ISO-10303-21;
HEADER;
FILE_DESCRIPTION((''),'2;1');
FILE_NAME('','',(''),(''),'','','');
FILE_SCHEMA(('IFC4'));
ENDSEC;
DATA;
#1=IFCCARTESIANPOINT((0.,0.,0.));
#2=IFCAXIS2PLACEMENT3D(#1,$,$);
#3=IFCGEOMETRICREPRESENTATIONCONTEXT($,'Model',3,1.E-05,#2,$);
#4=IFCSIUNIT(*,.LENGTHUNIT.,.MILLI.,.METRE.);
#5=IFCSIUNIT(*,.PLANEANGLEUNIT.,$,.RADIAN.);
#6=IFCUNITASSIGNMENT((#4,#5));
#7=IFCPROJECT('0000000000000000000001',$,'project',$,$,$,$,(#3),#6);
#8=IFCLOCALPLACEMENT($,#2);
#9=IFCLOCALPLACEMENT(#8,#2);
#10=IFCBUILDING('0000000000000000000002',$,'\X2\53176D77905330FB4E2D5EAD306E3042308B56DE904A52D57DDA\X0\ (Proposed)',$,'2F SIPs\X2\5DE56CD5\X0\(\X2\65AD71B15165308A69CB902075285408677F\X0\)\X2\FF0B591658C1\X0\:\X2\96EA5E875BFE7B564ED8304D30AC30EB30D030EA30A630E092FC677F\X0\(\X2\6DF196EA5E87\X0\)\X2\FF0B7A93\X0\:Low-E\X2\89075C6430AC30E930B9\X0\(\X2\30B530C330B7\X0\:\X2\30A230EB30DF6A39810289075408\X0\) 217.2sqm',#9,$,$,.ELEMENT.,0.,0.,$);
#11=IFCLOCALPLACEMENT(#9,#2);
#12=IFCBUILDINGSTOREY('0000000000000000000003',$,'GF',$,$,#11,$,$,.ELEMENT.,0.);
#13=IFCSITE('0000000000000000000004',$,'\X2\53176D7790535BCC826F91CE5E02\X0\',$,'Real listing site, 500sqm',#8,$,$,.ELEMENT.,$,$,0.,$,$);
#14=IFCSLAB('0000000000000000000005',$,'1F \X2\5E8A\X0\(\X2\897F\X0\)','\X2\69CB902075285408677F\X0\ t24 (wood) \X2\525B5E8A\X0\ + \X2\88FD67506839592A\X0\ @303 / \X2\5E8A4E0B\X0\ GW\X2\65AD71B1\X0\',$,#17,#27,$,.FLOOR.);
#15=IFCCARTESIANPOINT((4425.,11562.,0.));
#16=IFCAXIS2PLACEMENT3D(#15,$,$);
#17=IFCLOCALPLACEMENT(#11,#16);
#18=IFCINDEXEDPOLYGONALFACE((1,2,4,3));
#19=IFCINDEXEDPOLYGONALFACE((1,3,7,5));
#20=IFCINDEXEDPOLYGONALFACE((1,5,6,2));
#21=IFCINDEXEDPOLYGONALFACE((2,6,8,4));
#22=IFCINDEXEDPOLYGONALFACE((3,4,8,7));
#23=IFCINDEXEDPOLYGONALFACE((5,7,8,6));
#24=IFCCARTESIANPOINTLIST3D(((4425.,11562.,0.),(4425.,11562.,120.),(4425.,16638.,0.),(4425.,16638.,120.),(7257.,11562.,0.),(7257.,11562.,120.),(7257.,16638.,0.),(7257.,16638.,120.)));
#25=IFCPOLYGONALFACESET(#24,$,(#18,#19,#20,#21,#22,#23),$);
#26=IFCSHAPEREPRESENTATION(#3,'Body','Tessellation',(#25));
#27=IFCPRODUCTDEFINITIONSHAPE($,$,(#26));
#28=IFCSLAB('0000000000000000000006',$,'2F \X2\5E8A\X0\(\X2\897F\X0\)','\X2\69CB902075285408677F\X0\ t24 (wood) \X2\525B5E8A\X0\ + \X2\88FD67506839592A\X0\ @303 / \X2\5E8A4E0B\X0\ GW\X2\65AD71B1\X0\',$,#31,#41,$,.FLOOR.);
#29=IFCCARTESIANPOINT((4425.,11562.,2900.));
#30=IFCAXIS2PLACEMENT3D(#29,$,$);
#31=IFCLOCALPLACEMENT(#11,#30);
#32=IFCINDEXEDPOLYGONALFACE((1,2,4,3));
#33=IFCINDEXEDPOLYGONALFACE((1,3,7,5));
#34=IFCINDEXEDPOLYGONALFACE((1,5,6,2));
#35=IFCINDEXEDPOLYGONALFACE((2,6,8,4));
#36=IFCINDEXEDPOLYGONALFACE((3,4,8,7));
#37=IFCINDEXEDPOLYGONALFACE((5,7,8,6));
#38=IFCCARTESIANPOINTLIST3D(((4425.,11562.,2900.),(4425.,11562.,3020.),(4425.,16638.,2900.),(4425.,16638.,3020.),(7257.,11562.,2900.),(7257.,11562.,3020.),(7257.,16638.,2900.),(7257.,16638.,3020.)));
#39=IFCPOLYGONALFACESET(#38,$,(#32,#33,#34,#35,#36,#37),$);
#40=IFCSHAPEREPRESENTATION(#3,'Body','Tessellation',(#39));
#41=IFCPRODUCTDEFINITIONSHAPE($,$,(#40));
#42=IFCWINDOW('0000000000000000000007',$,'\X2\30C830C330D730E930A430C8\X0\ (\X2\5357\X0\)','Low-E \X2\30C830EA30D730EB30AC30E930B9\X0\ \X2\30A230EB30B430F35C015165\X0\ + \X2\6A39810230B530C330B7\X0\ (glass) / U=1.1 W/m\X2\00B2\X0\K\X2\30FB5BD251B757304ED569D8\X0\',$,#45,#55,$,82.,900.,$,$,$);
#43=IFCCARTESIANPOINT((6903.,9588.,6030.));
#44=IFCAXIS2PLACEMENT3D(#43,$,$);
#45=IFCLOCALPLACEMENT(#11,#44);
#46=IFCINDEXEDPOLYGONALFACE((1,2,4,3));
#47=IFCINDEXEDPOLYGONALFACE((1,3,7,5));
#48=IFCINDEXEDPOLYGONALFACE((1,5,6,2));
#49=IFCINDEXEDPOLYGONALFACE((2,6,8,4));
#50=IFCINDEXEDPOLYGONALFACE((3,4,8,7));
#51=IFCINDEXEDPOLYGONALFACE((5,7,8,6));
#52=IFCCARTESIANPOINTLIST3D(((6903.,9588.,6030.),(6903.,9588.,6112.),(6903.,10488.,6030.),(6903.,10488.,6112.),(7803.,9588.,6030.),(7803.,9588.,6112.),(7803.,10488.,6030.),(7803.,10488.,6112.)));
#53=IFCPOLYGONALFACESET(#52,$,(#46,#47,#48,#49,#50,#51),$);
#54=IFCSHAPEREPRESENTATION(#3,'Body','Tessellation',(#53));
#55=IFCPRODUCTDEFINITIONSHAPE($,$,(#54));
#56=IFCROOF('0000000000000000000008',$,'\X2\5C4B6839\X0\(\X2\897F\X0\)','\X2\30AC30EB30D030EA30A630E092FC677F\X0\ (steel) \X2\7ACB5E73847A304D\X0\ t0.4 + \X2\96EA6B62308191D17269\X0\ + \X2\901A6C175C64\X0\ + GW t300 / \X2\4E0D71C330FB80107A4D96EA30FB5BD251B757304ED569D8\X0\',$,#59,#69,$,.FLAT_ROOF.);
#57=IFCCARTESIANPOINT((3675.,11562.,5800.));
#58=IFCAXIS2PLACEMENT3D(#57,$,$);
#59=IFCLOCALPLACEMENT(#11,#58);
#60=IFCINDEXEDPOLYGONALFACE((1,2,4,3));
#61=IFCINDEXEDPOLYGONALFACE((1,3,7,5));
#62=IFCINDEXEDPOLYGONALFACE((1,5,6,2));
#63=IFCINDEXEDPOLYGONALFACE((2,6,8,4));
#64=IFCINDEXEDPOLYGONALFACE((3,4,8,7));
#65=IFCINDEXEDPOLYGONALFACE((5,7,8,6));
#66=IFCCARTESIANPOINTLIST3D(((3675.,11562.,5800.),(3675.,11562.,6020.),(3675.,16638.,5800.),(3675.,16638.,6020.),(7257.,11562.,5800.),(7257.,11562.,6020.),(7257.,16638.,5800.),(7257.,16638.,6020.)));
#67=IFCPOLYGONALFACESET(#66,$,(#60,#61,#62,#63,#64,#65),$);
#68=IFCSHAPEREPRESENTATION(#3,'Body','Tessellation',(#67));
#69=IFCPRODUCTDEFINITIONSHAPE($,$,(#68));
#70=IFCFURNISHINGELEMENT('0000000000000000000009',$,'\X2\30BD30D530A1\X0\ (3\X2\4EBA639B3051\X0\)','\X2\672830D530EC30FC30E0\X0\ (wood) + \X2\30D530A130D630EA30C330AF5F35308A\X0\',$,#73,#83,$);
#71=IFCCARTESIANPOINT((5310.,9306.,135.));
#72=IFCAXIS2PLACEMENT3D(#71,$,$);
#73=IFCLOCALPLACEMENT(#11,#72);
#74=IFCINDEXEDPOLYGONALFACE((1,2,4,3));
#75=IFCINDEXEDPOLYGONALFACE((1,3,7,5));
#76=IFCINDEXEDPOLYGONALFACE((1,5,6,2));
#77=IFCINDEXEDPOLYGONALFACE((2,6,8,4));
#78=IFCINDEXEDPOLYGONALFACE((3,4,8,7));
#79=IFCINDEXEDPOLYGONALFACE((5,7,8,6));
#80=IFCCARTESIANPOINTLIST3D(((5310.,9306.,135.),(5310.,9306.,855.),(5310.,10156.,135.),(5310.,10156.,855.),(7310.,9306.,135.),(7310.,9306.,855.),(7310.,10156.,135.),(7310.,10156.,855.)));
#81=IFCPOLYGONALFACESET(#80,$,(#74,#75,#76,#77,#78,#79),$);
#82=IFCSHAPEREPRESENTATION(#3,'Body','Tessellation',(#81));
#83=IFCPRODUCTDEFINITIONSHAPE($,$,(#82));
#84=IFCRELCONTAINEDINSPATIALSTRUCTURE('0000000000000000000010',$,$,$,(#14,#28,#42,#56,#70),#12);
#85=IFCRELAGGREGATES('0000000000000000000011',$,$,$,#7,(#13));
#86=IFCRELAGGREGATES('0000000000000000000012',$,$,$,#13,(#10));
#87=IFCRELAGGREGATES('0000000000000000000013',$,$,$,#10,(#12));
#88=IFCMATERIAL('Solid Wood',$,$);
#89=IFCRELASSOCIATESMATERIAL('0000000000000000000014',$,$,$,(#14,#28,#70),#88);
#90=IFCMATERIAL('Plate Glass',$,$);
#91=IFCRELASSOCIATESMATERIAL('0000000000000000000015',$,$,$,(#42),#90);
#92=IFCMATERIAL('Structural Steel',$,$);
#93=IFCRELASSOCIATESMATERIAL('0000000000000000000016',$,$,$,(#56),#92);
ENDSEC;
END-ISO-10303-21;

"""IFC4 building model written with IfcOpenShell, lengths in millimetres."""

from ifc_helpers import new_model, si_unit, frame, frame_2d, origin, place, context, project, spatial, rectangle, extrude, material, element, save


model = new_model("IFC4")

# Units and contexts
model_context = context("Model", 3, precision=1e-05, world=origin())
ifc_project = project(units=[si_unit("LENGTHUNIT", "METRE", prefix="MILLI"), si_unit("PLANEANGLEUNIT", "RADIAN")], contexts=[model_context])

# Site, building, storey
site_placement = place(None, origin())
site = spatial("IfcSite", under=ifc_project, at=site_placement, Name="北海道富良野市", ObjectType="Real listing site, 500sqm", CompositionType="ELEMENT", RefElevation=0.0)
building_placement = place(site_placement, origin())
building = spatial("IfcBuilding", under=site, at=building_placement, Name="北海道・中庭のある回遊動線 (Proposed)", ObjectType="2F SIPs工法(断熱入り構造用合板)＋外壁:雪庇対策付きガルバリウム鋼板(深雪庇)＋窓:Low-E複層ガラス(サッシ:アルミ樹脂複合) 217.2sqm", CompositionType="ELEMENT", ElevationOfRefHeight=0.0, ElevationOfTerrain=0.0)
storey_placement = place(building_placement, origin())
storey = spatial("IfcBuildingStorey", under=building, at=storey_placement, Name="GF", CompositionType="ELEMENT", Elevation=0.0)

# Shared definitions
ifc_material_1 = material(Name="Solid Wood")

# Slabs
slab_1_placement = place(storey_placement, frame((4425.0, 11562.0, 0.0)))
element("IfcSlab", 1, at=slab_1_placement, inside=storey, material=ifc_material_1, Name="1F 床(西)", Description="構造用合板 t24 (wood) 剛床 + 製材根太 @303 / 床下 GW断熱", PredefinedType="FLOOR", context=model_context, shape_type="SweptSolid", body=[
    extrude(rectangle(XDim=2832.0, YDim=5076.0, at=frame_2d((1416.0, 2538.0))), frame((4425.0, 11562.0, 0.0)), (0.0, 0.0, 1.0), 120.0),
])
slab_2_placement = place(storey_placement, frame((4425.0, 11562.0, 2900.0)))
element("IfcSlab", 2, at=slab_2_placement, inside=storey, material=ifc_material_1, Name="2F 床(西)", Description="構造用合板 t24 (wood) 剛床 + 製材根太 @303 / 床下 GW断熱", PredefinedType="FLOOR", context=model_context, shape_type="SweptSolid", body=[
    extrude(rectangle(XDim=2832.0, YDim=5076.0, at=frame_2d((1416.0, 2538.0))), frame((4425.0, 11562.0, 2900.0)), (0.0, 0.0, 1.0), 120.0),
])

# Window
ifc_material_2 = material(Name="Plate Glass")
window_placement = place(storey_placement, frame((6903.0, 9588.0, 6030.0)))
element("IfcWindow", 3, at=window_placement, inside=storey, material=ifc_material_2, Name="トップライト (南)", Description="Low-E トリプルガラス アルゴン封入 + 樹脂サッシ (glass) / U=1.1 W/m²K・寒冷地仕様", OverallHeight=82.0, OverallWidth=900.0, context=model_context, shape_type="SweptSolid", body=[
    extrude(rectangle(XDim=900.0, YDim=900.0, at=frame_2d((450.0, 450.0))), frame((6903.0, 9588.0, 6030.0)), (0.0, 0.0, 1.0), 82.0),
])

# Roof
ifc_material_3 = material(Name="Structural Steel")
for number, where, name in (
    (4, (3675.0, 11562.0, 5800.0), "屋根(西)"),
):
    element("IfcRoof", number, at=place(storey_placement, frame(where)), inside=storey, material=ifc_material_3, Name=name, Description="ガルバリウム鋼板 (steel) 立平葺き t0.4 + 雪止め金物 + 通気層 + GW t300 / 不燃・耐積雪・寒冷地仕様", PredefinedType="FLAT_ROOF", context=model_context, shape_type="SweptSolid", body=[
        extrude(rectangle(XDim=3582.0, YDim=5076.0, at=frame_2d((1791.0, 2538.0))), frame((3675.0, 11562.0, 5800.0)), (0.0, 0.0, 1.0), 220.0),
    ])

# Furnishing element
furnishing_placement = place(storey_placement, frame((5310.0, 9306.0, 135.0)))
element("IfcFurnishingElement", 5, at=furnishing_placement, inside=storey, material=ifc_material_1, Name="ソファ (3人掛け)", Description="木フレーム (wood) + ファブリック張り", context=model_context, shape_type="SweptSolid", body=[
    extrude(rectangle(XDim=2000.0, YDim=850.0, at=frame_2d((1000.0, 425.0))), frame((5310.0, 9306.0, 135.0)), (0.0, 0.0, 1.0), 720.0),
])

save(model, "model.ifc")
